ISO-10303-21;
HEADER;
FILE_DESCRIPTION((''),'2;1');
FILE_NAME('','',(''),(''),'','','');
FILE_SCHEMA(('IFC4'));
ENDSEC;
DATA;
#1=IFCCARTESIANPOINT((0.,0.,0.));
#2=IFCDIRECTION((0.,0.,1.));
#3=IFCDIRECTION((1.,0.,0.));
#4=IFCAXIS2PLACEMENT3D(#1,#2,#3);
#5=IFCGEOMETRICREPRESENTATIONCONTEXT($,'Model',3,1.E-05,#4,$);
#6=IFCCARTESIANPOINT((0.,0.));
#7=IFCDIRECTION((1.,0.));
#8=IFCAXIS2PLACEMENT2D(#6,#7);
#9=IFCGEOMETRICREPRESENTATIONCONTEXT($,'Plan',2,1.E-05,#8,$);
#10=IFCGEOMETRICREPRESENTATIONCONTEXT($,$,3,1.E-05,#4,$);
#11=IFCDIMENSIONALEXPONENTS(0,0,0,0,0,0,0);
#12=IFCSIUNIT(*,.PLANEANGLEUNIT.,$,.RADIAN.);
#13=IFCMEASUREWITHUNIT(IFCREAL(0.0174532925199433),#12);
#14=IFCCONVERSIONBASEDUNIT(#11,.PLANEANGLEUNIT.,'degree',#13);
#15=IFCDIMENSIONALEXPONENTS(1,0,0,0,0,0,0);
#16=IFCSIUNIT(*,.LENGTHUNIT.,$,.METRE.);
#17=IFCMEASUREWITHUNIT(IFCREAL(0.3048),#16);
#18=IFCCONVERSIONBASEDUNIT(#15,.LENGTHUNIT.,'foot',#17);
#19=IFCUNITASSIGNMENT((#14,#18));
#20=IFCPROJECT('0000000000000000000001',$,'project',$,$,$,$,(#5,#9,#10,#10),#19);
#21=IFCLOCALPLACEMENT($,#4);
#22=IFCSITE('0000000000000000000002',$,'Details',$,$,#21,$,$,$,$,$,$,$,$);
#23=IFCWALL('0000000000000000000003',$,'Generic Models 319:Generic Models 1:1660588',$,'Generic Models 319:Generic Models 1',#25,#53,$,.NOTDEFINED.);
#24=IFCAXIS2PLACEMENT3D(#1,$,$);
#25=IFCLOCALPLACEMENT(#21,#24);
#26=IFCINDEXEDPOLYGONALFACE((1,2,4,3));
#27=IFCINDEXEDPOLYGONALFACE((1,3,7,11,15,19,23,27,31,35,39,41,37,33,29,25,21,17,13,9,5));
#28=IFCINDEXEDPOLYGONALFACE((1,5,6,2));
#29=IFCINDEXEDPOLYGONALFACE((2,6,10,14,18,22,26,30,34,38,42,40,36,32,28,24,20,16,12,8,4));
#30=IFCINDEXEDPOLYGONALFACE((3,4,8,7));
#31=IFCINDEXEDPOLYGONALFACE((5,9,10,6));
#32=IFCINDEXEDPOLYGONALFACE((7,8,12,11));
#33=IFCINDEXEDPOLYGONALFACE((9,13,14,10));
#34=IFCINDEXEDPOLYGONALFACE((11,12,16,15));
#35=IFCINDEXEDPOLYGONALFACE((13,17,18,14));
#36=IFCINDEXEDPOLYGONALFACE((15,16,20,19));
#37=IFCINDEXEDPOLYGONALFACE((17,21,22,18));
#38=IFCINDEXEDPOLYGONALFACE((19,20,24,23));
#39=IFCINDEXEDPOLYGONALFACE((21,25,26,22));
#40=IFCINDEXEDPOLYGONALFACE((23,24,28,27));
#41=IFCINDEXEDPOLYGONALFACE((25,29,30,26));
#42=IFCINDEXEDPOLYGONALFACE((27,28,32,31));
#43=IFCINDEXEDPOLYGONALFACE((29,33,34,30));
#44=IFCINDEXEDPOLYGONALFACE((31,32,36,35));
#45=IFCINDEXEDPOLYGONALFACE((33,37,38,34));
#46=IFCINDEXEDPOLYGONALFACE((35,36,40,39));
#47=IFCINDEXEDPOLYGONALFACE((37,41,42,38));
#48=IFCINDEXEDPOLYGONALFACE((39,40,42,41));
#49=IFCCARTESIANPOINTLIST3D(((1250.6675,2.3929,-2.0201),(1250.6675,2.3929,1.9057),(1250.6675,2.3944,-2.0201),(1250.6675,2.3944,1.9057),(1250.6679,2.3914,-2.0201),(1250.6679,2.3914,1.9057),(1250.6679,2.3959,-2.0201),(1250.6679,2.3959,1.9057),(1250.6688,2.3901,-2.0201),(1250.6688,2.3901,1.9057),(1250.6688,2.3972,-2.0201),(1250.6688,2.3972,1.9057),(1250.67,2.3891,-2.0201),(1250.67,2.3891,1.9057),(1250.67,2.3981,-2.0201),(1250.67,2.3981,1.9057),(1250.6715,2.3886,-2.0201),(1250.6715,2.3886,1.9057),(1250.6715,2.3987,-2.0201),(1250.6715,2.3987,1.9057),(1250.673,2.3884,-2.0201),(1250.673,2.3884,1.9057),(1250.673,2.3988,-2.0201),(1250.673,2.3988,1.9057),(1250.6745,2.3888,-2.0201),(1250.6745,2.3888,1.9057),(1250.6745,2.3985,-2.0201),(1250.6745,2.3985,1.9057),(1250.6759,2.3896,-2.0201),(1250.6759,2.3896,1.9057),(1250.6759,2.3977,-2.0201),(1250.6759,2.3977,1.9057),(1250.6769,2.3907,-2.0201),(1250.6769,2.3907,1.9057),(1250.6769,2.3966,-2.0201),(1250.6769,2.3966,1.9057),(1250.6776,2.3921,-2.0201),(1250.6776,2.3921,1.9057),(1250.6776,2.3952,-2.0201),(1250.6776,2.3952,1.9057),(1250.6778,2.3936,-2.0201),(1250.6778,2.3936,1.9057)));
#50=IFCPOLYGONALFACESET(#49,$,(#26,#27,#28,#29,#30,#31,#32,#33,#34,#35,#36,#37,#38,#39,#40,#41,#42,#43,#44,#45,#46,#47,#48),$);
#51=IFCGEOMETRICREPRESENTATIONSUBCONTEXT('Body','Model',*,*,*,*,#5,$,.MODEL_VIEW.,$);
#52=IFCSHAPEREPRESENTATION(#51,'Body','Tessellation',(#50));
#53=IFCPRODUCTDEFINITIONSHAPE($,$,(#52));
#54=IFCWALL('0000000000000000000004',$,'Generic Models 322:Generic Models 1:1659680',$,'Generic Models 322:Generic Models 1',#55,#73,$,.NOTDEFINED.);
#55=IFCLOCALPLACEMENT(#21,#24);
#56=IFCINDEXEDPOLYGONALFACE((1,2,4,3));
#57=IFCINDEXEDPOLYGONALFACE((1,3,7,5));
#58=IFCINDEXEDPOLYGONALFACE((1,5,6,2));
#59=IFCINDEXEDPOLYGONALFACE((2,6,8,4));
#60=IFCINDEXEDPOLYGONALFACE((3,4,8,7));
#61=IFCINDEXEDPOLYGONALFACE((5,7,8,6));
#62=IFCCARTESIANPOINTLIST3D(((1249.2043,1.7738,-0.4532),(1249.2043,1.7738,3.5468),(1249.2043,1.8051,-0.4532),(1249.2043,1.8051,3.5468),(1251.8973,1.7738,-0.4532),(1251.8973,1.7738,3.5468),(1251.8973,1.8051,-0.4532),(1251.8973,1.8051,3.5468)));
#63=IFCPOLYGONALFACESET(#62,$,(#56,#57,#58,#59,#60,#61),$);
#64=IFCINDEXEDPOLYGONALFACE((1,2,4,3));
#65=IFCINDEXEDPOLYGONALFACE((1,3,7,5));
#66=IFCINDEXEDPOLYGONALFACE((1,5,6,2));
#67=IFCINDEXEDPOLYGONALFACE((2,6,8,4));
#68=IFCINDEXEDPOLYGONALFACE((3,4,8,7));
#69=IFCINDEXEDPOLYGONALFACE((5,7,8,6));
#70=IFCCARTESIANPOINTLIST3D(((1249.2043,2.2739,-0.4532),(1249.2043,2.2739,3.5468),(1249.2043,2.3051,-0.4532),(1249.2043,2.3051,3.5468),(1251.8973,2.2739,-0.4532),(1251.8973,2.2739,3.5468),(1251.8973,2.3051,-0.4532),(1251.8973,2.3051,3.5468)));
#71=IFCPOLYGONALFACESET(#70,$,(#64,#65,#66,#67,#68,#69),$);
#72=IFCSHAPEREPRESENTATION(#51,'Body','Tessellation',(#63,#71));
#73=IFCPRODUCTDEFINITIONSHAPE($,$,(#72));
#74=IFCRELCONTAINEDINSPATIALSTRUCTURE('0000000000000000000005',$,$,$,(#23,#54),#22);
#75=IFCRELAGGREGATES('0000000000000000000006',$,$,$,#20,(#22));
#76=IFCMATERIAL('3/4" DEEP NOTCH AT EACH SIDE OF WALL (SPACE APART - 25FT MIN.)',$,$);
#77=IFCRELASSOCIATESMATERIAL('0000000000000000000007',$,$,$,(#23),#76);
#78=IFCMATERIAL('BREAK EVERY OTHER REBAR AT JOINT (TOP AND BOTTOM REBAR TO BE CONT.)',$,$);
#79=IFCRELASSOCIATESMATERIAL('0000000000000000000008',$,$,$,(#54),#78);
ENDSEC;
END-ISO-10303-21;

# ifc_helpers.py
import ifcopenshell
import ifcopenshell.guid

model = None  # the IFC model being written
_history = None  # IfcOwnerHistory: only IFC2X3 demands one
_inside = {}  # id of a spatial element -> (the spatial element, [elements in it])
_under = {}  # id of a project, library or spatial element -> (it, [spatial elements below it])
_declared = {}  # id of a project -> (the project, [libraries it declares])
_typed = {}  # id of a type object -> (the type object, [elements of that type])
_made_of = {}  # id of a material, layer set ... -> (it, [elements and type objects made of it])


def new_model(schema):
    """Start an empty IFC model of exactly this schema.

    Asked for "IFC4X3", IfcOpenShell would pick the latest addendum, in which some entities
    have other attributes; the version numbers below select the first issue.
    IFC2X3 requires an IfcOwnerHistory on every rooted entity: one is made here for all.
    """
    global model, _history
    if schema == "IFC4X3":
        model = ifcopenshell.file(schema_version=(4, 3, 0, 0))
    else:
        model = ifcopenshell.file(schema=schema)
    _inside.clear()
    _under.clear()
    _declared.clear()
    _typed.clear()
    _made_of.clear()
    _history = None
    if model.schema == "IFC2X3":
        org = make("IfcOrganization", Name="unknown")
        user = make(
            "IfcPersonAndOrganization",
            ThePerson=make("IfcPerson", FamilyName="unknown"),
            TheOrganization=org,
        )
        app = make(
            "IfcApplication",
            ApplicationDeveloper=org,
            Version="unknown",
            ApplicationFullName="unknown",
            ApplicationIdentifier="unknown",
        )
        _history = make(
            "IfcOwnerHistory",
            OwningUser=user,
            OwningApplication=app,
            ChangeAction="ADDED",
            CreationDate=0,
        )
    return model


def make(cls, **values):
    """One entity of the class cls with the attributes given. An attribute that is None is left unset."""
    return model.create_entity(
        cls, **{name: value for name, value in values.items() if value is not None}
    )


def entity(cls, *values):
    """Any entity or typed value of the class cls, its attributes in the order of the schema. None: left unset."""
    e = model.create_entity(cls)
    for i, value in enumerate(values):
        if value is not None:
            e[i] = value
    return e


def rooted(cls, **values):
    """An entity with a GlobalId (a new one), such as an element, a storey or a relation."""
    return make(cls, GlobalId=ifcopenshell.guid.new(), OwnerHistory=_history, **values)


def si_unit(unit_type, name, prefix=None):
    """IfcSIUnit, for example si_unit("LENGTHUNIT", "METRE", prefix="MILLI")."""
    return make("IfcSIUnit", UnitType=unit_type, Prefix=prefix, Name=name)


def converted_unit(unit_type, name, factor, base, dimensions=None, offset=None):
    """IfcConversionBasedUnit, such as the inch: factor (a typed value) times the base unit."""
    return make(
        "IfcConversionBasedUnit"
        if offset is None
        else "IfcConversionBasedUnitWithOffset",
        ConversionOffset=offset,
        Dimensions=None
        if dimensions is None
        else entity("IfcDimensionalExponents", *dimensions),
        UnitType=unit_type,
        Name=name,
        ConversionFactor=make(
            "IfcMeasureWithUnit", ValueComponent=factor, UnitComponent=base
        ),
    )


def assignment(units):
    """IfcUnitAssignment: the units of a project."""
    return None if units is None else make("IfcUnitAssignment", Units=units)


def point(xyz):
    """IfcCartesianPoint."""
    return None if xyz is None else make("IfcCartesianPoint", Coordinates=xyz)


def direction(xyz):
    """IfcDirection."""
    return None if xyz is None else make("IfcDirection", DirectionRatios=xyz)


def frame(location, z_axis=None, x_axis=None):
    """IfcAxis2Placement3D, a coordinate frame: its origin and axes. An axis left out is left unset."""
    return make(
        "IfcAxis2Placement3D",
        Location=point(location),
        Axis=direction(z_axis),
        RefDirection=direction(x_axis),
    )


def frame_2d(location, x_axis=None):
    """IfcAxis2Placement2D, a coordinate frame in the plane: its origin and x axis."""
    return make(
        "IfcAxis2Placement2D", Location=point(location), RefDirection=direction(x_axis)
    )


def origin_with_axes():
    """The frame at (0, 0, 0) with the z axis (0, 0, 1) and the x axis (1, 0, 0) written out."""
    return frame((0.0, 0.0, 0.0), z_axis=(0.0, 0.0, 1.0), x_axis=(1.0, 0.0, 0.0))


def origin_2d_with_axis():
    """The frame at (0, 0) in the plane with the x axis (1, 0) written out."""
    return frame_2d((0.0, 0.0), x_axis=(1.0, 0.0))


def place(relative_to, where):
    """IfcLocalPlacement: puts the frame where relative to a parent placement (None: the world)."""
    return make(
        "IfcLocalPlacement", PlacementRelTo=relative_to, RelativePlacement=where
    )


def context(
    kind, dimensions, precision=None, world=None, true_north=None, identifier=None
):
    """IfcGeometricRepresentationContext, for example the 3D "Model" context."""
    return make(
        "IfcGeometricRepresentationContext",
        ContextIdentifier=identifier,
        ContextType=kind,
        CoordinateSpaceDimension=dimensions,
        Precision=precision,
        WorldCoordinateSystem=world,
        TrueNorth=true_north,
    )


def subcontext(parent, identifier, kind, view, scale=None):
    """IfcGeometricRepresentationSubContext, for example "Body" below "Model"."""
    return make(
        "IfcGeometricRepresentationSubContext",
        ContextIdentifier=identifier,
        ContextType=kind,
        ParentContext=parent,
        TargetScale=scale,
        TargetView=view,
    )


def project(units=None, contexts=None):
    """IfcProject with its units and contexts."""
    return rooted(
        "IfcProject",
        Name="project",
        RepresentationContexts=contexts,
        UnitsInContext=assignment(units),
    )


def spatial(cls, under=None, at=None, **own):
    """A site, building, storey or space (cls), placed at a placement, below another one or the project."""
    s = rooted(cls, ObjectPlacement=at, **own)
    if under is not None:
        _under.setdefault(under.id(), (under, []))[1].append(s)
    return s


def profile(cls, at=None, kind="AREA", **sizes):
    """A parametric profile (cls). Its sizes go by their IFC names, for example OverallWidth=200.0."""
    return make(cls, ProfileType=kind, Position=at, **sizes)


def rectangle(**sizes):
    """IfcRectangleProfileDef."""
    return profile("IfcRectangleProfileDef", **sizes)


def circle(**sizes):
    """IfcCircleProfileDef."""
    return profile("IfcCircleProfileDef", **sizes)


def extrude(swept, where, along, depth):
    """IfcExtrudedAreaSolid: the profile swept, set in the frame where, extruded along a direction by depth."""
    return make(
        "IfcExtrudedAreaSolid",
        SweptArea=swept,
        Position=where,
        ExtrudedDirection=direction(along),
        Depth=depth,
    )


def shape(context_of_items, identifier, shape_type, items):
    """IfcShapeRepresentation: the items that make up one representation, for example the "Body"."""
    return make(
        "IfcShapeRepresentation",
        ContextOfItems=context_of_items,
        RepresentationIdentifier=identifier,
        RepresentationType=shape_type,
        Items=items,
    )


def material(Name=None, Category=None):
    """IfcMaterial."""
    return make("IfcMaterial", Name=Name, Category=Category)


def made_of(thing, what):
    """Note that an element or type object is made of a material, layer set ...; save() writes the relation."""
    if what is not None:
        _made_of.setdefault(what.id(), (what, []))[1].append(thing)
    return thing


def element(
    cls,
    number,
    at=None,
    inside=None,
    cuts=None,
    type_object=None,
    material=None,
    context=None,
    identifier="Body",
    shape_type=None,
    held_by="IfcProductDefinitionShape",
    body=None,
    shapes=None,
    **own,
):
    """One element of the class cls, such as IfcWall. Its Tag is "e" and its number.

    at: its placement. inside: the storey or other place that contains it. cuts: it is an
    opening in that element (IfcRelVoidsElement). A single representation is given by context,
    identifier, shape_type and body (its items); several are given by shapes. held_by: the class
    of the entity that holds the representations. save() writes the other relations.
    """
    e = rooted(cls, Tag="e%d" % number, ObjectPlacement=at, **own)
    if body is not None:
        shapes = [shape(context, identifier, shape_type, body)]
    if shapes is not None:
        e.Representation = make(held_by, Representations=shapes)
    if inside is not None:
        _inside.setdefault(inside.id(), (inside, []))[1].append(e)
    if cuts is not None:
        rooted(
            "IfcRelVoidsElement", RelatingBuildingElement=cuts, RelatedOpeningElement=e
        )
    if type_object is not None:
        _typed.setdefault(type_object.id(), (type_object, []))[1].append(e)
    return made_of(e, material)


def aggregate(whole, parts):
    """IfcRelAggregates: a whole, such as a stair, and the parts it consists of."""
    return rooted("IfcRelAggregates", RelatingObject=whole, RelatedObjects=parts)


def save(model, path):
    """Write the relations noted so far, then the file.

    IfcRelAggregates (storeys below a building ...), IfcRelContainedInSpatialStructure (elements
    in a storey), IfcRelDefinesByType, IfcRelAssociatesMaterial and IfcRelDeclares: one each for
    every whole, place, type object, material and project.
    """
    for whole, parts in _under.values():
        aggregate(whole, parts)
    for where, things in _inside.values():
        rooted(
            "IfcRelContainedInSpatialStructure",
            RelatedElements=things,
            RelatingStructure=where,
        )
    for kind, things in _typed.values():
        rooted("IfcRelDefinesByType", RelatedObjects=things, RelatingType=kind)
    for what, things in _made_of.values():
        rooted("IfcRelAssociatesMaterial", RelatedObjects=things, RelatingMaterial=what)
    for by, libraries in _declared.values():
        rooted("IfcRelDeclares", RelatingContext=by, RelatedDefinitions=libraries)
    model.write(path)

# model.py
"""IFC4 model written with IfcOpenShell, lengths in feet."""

from ifc_helpers import new_model, entity, si_unit, converted_unit, frame, origin_with_axes, origin_2d_with_axis, place, context, subcontext, project, spatial, rectangle, circle, extrude, material, element, save


model = new_model("IFC4")

# Units and contexts
model_context = context("Model", 3, precision=1e-05, world=origin_with_axes())
plan_context = context("Plan", 2, precision=1e-05, world=origin_2d_with_axis())
context_of_model = context(None, 3, precision=1e-05, world=origin_with_axes())
body_context = subcontext(model_context, "Body", "Model", "MODEL_VIEW")
ifc_project = project(units=[converted_unit("PLANEANGLEUNIT", "degree", entity("IfcReal", 0.0174532925199433), si_unit("PLANEANGLEUNIT", "RADIAN"), dimensions=[0, 0, 0, 0, 0, 0, 0]), converted_unit("LENGTHUNIT", "foot", entity("IfcReal", 0.3048), si_unit("LENGTHUNIT", "METRE"), dimensions=[1, 0, 0, 0, 0, 0, 0])], contexts=[model_context, plan_context, context_of_model, context_of_model])

# Site
site_placement = place(None, origin_with_axes())
site = spatial("IfcSite", under=ifc_project, at=site_placement, Name="Details")

# Walls
ifc_material_1 = material(Name="3/4\" DEEP NOTCH AT EACH SIDE OF WALL (SPACE APART - 25FT MIN.)")
wall_1_placement = place(site_placement, frame((1250.6674, 2.3884, -2.0201), z_axis=(0.0, 0.0, 1.0), x_axis=(0.0, 1.0, 0.0)))
element("IfcWall", 1, at=wall_1_placement, inside=site, material=ifc_material_1, Name="Generic Models 319:Generic Models 1:1660588", ObjectType="Generic Models 319:Generic Models 1", PredefinedType="NOTDEFINED", context=body_context, shape_type="SweptSolid", body=[
    extrude(circle(Radius=0.0052, at=origin_2d_with_axis()), frame((0.0052, -0.0052, 0.0), z_axis=(0.0, 0.0, 1.0), x_axis=(0.0, -1.0, 0.0)), (0.0, 0.0, 1.0), 3.9258),
])
ifc_material_2 = material(Name="BREAK EVERY OTHER REBAR AT JOINT (TOP AND BOTTOM REBAR TO BE CONT.)")
wall_2_placement = place(site_placement, frame((1249.2043, 1.7738, -0.4532), z_axis=(0.0, 0.0, 1.0), x_axis=(1.0, 0.0, 0.0)))
element("IfcWall", 2, at=wall_2_placement, inside=site, material=ifc_material_2, Name="Generic Models 322:Generic Models 1:1659680", ObjectType="Generic Models 322:Generic Models 1", PredefinedType="NOTDEFINED", context=body_context, shape_type="SweptSolid", body=[
    extrude(rectangle(XDim=0.0312, YDim=2.693, at=origin_2d_with_axis()), frame((1.3465, 0.0156, 0.0), z_axis=(0.0, 0.0, 1.0), x_axis=(0.0, 1.0, 0.0)), (0.0, 0.0, 1.0), 4.0),
    extrude(rectangle(XDim=0.0312, YDim=2.693, at=origin_2d_with_axis()), frame((1.3465, 0.5157, 0.0), z_axis=(0.0, 0.0, 1.0), x_axis=(0.0, 1.0, 0.0)), (0.0, 0.0, 1.0), 4.0),
])

save(model, "model.ifc")
